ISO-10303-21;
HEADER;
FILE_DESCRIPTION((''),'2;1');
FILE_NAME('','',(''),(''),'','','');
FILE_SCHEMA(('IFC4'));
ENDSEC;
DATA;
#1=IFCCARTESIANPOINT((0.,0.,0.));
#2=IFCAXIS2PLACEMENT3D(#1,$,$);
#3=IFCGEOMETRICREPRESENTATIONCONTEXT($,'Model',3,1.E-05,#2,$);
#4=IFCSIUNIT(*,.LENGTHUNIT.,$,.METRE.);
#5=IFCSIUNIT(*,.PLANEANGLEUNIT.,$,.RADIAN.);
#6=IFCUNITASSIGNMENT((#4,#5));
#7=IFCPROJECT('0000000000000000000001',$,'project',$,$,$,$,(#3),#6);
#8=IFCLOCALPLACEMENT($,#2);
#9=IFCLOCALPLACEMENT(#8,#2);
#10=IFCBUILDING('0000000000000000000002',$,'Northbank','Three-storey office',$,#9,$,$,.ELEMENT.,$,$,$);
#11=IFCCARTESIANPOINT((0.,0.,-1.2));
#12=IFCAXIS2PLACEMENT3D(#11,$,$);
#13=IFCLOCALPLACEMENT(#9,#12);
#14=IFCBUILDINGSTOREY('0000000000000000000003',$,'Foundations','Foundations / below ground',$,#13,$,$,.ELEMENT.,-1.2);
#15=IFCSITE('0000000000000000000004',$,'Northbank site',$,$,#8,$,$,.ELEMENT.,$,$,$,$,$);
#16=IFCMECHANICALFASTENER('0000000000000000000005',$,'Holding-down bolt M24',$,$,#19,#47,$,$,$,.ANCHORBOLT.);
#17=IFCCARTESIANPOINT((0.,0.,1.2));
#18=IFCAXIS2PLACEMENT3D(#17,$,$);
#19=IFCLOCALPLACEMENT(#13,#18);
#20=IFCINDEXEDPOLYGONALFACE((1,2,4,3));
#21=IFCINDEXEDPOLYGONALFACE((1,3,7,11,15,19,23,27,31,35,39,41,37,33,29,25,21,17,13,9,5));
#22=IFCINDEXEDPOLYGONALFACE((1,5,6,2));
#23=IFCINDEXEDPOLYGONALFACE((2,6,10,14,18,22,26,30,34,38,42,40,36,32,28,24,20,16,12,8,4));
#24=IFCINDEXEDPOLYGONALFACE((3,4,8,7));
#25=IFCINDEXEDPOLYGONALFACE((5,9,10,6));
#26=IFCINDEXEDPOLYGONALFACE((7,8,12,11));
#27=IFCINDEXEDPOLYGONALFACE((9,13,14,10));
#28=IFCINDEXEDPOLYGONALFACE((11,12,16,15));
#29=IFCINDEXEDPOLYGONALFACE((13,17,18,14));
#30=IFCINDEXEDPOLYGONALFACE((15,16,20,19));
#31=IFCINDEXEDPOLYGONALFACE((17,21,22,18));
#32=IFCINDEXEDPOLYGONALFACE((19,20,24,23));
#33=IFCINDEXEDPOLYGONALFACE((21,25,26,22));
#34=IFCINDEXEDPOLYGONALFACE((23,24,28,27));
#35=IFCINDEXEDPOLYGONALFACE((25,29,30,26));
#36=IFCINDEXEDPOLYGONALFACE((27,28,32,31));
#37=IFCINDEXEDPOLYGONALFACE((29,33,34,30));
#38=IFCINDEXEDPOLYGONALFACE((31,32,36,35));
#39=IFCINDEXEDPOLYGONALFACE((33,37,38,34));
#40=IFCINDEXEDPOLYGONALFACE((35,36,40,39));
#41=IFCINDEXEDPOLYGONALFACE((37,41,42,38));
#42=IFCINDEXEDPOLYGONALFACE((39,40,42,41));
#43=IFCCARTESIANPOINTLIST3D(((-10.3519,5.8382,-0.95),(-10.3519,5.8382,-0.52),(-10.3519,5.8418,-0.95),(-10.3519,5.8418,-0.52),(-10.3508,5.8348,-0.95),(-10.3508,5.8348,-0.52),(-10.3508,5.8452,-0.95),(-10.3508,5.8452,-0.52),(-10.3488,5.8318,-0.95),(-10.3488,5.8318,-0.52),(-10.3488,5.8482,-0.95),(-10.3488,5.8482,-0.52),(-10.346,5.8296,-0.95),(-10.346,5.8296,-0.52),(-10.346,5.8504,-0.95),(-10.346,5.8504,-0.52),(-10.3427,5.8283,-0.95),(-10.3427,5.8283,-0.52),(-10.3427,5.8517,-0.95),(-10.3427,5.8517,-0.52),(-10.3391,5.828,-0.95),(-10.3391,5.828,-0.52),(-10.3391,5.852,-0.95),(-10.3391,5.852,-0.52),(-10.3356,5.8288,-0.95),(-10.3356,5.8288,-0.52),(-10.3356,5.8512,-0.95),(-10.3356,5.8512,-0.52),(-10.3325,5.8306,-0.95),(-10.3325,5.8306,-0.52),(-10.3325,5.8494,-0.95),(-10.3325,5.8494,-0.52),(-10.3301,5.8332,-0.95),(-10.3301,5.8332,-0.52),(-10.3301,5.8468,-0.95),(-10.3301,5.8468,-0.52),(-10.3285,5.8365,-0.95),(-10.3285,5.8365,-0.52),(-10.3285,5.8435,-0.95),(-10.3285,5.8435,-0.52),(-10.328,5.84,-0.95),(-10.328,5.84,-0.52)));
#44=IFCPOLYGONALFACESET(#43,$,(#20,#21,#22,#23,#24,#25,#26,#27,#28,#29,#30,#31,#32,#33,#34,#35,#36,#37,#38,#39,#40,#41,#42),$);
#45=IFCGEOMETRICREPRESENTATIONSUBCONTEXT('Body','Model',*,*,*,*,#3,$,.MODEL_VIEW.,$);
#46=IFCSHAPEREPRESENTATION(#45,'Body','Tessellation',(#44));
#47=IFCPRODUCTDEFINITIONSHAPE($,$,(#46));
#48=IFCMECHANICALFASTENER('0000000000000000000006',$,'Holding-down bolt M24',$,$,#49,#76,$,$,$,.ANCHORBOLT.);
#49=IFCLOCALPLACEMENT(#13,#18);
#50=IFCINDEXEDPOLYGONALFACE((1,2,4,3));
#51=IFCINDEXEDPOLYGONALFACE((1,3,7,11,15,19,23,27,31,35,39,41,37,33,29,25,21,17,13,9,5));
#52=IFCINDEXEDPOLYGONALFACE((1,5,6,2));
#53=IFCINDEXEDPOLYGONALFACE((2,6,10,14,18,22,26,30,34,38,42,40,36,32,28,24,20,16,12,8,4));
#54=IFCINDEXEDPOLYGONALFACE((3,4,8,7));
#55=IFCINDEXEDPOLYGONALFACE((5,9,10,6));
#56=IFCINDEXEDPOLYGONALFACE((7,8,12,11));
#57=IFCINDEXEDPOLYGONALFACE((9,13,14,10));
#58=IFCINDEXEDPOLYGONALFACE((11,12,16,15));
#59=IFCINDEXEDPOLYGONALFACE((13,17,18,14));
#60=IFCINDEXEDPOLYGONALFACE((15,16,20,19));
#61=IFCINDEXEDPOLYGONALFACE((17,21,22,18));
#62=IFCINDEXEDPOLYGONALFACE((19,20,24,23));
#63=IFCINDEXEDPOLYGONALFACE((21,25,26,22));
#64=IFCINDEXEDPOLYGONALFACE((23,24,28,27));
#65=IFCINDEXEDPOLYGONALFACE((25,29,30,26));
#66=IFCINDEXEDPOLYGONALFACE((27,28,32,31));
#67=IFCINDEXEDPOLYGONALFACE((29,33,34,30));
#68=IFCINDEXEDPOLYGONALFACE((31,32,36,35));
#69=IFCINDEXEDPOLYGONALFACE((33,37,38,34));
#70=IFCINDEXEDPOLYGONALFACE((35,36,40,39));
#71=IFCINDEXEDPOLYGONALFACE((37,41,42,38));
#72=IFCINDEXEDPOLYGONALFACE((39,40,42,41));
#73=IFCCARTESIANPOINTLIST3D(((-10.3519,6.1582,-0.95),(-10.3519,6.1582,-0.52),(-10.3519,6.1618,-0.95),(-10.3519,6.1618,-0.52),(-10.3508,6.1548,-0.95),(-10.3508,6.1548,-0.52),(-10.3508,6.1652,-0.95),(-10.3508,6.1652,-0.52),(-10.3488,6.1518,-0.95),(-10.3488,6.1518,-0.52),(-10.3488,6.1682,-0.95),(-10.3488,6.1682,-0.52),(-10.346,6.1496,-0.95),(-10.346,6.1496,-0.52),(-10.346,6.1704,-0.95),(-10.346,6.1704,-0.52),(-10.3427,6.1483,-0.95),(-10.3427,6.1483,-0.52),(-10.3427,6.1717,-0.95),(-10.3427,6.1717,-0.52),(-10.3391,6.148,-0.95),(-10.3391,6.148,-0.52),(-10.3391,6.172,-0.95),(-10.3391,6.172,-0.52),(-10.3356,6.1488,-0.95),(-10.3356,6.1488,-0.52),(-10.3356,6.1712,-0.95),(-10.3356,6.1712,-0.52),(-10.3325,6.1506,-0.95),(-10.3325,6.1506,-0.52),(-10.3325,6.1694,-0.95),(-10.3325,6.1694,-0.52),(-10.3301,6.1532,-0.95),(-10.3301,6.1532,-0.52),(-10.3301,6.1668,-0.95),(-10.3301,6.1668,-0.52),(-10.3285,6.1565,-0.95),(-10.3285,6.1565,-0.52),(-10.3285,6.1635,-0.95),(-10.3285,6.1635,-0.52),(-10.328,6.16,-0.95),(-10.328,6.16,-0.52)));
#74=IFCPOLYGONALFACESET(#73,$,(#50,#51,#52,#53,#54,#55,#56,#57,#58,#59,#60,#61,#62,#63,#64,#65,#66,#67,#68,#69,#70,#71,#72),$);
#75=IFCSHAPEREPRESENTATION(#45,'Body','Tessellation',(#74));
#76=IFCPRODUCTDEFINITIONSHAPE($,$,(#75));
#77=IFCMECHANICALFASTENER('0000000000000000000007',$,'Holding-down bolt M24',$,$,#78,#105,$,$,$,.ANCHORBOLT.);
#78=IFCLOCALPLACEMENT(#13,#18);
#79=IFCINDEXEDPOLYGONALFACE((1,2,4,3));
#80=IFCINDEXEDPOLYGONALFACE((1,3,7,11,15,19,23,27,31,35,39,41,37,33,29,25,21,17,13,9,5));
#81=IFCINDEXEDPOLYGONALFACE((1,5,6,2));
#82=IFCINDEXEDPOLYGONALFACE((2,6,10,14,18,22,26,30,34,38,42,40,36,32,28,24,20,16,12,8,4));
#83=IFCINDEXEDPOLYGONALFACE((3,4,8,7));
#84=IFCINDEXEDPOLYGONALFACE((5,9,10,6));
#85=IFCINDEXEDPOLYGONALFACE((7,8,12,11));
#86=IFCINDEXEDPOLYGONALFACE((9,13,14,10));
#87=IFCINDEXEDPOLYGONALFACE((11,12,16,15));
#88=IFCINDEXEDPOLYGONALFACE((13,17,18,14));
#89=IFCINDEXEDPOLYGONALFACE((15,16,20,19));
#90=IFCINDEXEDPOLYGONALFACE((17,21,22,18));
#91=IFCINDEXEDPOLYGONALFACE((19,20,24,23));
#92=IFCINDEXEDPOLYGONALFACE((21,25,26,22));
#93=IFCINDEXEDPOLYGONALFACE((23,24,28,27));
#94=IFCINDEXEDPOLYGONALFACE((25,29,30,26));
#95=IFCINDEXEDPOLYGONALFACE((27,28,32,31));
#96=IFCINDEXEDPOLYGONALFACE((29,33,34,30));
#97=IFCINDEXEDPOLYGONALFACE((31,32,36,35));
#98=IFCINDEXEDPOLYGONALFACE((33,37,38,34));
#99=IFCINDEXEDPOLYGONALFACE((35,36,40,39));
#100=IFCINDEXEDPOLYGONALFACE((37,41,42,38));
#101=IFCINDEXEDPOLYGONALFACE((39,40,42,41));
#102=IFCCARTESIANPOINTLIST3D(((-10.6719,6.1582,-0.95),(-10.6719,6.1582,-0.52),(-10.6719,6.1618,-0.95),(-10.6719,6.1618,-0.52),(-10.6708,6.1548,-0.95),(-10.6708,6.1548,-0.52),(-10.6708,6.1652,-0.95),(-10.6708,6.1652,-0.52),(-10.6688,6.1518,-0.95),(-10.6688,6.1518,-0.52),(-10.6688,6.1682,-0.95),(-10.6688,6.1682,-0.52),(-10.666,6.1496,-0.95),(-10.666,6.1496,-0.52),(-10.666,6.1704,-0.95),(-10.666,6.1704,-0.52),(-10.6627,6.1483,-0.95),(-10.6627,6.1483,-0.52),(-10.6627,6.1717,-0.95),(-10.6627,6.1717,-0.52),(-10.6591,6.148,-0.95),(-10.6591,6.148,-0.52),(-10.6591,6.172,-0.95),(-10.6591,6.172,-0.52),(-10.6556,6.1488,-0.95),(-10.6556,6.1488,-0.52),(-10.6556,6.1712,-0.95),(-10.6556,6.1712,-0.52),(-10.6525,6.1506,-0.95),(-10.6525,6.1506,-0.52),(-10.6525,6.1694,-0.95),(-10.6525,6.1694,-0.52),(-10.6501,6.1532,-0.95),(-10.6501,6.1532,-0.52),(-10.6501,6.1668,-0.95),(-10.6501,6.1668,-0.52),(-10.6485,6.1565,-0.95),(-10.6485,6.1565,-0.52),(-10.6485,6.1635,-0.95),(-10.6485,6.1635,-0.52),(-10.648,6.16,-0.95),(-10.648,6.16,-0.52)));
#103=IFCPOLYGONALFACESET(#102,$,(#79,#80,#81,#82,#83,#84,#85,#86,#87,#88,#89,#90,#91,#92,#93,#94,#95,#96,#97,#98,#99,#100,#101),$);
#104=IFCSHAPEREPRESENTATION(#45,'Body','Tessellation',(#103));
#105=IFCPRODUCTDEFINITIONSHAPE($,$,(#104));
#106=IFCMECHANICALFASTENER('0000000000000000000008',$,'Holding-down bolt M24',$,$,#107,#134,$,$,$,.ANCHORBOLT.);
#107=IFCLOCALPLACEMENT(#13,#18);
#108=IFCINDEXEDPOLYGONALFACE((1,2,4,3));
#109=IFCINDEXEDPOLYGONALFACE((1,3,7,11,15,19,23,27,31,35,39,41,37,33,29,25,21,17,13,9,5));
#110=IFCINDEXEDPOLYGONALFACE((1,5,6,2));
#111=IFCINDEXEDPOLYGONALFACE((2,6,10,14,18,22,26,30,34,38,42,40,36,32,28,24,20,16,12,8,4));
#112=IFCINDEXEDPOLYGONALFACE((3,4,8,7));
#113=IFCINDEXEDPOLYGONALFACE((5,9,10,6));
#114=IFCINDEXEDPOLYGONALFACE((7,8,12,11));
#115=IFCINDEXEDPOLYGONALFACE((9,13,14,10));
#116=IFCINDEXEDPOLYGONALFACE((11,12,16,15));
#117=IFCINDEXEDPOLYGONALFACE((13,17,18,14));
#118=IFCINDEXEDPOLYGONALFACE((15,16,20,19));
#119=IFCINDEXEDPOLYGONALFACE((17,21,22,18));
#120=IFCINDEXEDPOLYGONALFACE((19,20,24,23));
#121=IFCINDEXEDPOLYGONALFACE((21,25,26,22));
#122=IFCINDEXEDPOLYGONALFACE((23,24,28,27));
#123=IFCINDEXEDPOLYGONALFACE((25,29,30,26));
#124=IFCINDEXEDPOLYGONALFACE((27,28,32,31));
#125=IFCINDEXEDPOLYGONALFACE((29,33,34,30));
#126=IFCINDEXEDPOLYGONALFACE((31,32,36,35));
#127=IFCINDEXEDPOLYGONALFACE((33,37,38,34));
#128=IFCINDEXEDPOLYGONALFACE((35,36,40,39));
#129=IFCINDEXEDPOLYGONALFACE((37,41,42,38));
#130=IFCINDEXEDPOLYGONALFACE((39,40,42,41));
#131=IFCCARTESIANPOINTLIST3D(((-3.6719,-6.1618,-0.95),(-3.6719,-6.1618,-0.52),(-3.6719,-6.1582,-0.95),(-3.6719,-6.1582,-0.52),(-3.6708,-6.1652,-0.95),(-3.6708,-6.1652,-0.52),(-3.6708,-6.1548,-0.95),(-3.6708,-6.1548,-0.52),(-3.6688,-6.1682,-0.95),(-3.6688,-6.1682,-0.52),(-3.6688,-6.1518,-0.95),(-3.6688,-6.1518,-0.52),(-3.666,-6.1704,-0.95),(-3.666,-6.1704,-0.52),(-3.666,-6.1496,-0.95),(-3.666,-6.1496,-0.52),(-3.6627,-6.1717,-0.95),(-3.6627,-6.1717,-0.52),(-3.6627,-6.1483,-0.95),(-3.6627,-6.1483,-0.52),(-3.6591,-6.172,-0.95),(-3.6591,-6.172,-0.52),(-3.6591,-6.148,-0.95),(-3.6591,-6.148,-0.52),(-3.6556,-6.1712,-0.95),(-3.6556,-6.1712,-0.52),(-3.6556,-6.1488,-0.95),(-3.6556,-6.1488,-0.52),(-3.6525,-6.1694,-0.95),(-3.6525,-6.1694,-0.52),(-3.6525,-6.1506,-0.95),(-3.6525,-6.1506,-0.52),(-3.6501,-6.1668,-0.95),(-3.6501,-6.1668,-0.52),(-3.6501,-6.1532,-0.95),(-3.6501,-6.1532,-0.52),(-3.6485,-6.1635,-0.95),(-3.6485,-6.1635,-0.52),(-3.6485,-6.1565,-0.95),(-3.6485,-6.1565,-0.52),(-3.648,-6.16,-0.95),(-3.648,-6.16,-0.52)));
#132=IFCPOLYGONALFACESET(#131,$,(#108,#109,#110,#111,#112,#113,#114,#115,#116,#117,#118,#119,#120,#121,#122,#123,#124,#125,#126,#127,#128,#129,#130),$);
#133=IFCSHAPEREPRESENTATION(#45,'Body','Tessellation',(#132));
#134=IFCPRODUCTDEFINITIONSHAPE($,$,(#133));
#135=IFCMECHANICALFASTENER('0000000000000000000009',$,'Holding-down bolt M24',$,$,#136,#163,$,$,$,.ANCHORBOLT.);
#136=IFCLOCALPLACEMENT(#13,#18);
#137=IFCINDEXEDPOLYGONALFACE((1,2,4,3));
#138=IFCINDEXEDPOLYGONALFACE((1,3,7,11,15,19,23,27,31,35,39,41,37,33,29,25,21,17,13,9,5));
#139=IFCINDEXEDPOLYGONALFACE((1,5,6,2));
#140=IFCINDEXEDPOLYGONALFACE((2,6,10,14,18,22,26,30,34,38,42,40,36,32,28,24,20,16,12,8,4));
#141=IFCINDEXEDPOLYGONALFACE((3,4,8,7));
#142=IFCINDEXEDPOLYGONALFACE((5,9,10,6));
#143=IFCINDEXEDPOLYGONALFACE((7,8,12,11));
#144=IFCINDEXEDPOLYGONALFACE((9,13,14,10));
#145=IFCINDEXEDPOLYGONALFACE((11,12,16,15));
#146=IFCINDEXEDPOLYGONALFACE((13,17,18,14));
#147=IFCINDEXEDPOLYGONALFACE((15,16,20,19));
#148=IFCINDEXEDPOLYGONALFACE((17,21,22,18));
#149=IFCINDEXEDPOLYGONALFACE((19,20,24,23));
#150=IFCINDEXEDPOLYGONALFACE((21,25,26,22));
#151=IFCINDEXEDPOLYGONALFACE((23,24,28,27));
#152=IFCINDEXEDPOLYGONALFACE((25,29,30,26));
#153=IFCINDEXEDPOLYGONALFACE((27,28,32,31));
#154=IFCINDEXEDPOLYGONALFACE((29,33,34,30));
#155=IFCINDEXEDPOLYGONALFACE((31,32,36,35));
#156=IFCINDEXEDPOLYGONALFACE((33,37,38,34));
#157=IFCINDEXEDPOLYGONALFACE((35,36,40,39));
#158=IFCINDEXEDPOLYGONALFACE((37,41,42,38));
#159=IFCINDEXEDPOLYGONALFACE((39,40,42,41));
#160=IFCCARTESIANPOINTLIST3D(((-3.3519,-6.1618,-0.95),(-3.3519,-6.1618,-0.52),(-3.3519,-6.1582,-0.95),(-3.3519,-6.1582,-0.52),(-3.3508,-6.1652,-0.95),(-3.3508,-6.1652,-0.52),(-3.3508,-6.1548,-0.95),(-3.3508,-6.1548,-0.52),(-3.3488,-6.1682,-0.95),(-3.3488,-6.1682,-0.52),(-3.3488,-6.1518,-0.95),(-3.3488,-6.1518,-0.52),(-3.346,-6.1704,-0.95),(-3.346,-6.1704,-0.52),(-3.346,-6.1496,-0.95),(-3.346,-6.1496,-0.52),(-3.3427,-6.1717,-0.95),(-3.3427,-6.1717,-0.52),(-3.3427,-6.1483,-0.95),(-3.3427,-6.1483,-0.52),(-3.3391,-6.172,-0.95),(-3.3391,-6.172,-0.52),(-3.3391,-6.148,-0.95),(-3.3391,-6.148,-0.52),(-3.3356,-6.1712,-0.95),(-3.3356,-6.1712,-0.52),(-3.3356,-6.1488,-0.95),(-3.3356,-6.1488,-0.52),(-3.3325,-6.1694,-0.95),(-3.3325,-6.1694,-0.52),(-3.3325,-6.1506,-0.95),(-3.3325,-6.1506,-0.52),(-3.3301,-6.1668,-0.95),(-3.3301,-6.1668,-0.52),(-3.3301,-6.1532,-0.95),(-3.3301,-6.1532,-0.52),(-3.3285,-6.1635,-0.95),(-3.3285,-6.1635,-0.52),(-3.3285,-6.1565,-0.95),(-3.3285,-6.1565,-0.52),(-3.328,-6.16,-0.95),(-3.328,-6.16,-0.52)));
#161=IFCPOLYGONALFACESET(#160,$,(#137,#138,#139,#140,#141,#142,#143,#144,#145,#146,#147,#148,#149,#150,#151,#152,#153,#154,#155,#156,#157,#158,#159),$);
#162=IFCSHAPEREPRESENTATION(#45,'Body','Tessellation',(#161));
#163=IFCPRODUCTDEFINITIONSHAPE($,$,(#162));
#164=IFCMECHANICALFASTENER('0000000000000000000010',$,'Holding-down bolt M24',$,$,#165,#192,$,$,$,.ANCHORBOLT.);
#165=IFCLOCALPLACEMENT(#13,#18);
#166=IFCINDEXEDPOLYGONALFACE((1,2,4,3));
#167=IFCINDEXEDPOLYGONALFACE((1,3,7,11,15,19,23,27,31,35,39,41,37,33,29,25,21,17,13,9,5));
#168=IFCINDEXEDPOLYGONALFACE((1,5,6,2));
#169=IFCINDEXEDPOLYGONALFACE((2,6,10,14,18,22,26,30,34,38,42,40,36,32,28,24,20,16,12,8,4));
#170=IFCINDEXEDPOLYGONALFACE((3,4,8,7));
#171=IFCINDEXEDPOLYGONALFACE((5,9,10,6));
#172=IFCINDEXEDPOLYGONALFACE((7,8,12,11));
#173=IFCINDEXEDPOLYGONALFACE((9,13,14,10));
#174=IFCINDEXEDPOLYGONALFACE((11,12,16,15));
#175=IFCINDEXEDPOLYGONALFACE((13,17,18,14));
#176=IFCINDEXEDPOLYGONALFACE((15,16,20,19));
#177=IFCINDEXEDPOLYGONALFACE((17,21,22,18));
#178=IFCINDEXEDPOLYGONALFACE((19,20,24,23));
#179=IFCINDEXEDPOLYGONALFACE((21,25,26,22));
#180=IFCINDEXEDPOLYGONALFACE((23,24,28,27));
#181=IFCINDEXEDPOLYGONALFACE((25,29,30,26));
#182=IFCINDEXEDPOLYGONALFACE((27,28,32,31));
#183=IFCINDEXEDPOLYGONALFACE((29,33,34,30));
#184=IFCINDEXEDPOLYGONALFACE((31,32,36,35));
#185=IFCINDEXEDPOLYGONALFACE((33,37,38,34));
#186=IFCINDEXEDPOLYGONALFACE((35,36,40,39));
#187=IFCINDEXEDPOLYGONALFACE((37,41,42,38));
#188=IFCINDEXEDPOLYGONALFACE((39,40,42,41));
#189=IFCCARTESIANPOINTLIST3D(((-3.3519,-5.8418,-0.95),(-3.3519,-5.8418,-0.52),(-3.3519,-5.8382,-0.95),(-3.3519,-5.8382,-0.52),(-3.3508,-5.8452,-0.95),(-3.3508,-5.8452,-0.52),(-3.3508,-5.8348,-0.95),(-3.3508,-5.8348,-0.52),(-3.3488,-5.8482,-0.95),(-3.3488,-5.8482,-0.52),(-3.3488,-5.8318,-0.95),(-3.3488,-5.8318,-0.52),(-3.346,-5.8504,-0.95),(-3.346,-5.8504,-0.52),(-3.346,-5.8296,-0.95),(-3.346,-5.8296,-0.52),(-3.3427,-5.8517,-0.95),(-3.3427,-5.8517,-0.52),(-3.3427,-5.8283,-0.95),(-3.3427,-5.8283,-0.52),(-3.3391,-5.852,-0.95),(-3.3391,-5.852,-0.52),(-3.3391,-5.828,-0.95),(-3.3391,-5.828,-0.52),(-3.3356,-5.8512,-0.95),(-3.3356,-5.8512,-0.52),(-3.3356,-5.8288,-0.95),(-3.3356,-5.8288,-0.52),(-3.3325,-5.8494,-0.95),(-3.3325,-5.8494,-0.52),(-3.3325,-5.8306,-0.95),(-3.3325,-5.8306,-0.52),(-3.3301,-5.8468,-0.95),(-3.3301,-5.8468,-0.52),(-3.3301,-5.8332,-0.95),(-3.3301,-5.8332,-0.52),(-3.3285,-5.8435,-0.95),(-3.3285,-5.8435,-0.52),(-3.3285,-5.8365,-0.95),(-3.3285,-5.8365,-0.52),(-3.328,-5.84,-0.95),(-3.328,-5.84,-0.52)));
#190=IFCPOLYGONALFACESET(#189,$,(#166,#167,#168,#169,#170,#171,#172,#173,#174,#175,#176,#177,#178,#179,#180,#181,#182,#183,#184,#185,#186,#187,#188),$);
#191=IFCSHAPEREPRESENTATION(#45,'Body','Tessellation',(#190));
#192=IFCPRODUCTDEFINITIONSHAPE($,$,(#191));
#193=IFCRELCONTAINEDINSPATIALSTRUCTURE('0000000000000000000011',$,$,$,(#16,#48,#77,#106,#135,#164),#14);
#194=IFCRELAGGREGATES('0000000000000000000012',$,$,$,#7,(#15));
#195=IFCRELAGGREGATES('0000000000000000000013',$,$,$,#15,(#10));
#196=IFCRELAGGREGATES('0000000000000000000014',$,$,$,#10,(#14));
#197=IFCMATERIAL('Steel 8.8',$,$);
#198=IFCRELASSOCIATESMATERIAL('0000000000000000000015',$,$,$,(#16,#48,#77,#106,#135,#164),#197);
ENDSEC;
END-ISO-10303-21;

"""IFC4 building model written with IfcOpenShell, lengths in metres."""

from ifc_helpers import new_model, si_unit, frame, origin, place, context, subcontext, project, spatial, circle, extrude, material, element, save


model = new_model("IFC4")

# Units and contexts
model_context = context("Model", 3, precision=1e-05, world=origin())
body_context = subcontext(model_context, "Body", "Model", "MODEL_VIEW")
ifc_project = project(units=[si_unit("LENGTHUNIT", "METRE"), si_unit("PLANEANGLEUNIT", "RADIAN")], contexts=[model_context])

# Site, building, storey
site_placement = place(None, origin())
site = spatial("IfcSite", under=ifc_project, at=site_placement, Name="Northbank site", CompositionType="ELEMENT")
building_placement = place(site_placement, origin())
building = spatial("IfcBuilding", under=site, at=building_placement, Name="Northbank", Description="Three-storey office", CompositionType="ELEMENT")
storey_placement = place(building_placement, frame((0.0, 0.0, -1.2)))
storey = spatial("IfcBuildingStorey", under=building, at=storey_placement, Name="Foundations", Description="Foundations / below ground", CompositionType="ELEMENT", Elevation=-1.2)

# Mechanical fasteners
ifc_material_1 = material(Name="Steel 8.8")
mechanical_fastener_1_placement = place(storey_placement, frame((0.0, 0.0, 1.2)))
element("IfcMechanicalFastener", 1, at=mechanical_fastener_1_placement, inside=storey, material=ifc_material_1, Name="Holding-down bolt M24", PredefinedType="ANCHORBOLT", context=body_context, shape_type="SweptSolid", body=[
    extrude(circle(Radius=0.012), frame((-10.34, 5.84, -0.95), z_axis=(0.0, 0.0, 1.0), x_axis=(1.0, 0.0, 0.0)), (0.0, 0.0, 1.0), 0.43),
])
mechanical_fastener_2_placement = place(storey_placement, frame((0.0, 0.0, 1.2)))
element("IfcMechanicalFastener", 2, at=mechanical_fastener_2_placement, inside=storey, material=ifc_material_1, Name="Holding-down bolt M24", PredefinedType="ANCHORBOLT", context=body_context, shape_type="SweptSolid", body=[
    extrude(circle(Radius=0.012), frame((-10.34, 6.16, -0.95), z_axis=(0.0, 0.0, 1.0), x_axis=(1.0, 0.0, 0.0)), (0.0, 0.0, 1.0), 0.43),
])
mechanical_fastener_3_placement = place(storey_placement, frame((0.0, 0.0, 1.2)))
element("IfcMechanicalFastener", 3, at=mechanical_fastener_3_placement, inside=storey, material=ifc_material_1, Name="Holding-down bolt M24", PredefinedType="ANCHORBOLT", context=body_context, shape_type="SweptSolid", body=[
    extrude(circle(Radius=0.012), frame((-10.66, 6.16, -0.95), z_axis=(0.0, 0.0, 1.0), x_axis=(1.0, 0.0, 0.0)), (0.0, 0.0, 1.0), 0.43),
])
mechanical_fastener_4_placement = place(storey_placement, frame((0.0, 0.0, 1.2)))
element("IfcMechanicalFastener", 4, at=mechanical_fastener_4_placement, inside=storey, material=ifc_material_1, Name="Holding-down bolt M24", PredefinedType="ANCHORBOLT", context=body_context, shape_type="SweptSolid", body=[
    extrude(circle(Radius=0.012), frame((-3.66, -6.16, -0.95), z_axis=(0.0, 0.0, 1.0), x_axis=(1.0, 0.0, 0.0)), (0.0, 0.0, 1.0), 0.43),
])
mechanical_fastener_5_placement = place(storey_placement, frame((0.0, 0.0, 1.2)))
element("IfcMechanicalFastener", 5, at=mechanical_fastener_5_placement, inside=storey, material=ifc_material_1, Name="Holding-down bolt M24", PredefinedType="ANCHORBOLT", context=body_context, shape_type="SweptSolid", body=[
    extrude(circle(Radius=0.012), frame((-3.34, -6.16, -0.95), z_axis=(0.0, 0.0, 1.0), x_axis=(1.0, 0.0, 0.0)), (0.0, 0.0, 1.0), 0.43),
])
mechanical_fastener_6_placement = place(storey_placement, frame((0.0, 0.0, 1.2)))
element("IfcMechanicalFastener", 6, at=mechanical_fastener_6_placement, inside=storey, material=ifc_material_1, Name="Holding-down bolt M24", PredefinedType="ANCHORBOLT", context=body_context, shape_type="SweptSolid", body=[
    extrude(circle(Radius=0.012), frame((-3.34, -5.84, -0.95), z_axis=(0.0, 0.0, 1.0), x_axis=(1.0, 0.0, 0.0)), (0.0, 0.0, 1.0), 0.43),
])

save(model, "model.ifc")
